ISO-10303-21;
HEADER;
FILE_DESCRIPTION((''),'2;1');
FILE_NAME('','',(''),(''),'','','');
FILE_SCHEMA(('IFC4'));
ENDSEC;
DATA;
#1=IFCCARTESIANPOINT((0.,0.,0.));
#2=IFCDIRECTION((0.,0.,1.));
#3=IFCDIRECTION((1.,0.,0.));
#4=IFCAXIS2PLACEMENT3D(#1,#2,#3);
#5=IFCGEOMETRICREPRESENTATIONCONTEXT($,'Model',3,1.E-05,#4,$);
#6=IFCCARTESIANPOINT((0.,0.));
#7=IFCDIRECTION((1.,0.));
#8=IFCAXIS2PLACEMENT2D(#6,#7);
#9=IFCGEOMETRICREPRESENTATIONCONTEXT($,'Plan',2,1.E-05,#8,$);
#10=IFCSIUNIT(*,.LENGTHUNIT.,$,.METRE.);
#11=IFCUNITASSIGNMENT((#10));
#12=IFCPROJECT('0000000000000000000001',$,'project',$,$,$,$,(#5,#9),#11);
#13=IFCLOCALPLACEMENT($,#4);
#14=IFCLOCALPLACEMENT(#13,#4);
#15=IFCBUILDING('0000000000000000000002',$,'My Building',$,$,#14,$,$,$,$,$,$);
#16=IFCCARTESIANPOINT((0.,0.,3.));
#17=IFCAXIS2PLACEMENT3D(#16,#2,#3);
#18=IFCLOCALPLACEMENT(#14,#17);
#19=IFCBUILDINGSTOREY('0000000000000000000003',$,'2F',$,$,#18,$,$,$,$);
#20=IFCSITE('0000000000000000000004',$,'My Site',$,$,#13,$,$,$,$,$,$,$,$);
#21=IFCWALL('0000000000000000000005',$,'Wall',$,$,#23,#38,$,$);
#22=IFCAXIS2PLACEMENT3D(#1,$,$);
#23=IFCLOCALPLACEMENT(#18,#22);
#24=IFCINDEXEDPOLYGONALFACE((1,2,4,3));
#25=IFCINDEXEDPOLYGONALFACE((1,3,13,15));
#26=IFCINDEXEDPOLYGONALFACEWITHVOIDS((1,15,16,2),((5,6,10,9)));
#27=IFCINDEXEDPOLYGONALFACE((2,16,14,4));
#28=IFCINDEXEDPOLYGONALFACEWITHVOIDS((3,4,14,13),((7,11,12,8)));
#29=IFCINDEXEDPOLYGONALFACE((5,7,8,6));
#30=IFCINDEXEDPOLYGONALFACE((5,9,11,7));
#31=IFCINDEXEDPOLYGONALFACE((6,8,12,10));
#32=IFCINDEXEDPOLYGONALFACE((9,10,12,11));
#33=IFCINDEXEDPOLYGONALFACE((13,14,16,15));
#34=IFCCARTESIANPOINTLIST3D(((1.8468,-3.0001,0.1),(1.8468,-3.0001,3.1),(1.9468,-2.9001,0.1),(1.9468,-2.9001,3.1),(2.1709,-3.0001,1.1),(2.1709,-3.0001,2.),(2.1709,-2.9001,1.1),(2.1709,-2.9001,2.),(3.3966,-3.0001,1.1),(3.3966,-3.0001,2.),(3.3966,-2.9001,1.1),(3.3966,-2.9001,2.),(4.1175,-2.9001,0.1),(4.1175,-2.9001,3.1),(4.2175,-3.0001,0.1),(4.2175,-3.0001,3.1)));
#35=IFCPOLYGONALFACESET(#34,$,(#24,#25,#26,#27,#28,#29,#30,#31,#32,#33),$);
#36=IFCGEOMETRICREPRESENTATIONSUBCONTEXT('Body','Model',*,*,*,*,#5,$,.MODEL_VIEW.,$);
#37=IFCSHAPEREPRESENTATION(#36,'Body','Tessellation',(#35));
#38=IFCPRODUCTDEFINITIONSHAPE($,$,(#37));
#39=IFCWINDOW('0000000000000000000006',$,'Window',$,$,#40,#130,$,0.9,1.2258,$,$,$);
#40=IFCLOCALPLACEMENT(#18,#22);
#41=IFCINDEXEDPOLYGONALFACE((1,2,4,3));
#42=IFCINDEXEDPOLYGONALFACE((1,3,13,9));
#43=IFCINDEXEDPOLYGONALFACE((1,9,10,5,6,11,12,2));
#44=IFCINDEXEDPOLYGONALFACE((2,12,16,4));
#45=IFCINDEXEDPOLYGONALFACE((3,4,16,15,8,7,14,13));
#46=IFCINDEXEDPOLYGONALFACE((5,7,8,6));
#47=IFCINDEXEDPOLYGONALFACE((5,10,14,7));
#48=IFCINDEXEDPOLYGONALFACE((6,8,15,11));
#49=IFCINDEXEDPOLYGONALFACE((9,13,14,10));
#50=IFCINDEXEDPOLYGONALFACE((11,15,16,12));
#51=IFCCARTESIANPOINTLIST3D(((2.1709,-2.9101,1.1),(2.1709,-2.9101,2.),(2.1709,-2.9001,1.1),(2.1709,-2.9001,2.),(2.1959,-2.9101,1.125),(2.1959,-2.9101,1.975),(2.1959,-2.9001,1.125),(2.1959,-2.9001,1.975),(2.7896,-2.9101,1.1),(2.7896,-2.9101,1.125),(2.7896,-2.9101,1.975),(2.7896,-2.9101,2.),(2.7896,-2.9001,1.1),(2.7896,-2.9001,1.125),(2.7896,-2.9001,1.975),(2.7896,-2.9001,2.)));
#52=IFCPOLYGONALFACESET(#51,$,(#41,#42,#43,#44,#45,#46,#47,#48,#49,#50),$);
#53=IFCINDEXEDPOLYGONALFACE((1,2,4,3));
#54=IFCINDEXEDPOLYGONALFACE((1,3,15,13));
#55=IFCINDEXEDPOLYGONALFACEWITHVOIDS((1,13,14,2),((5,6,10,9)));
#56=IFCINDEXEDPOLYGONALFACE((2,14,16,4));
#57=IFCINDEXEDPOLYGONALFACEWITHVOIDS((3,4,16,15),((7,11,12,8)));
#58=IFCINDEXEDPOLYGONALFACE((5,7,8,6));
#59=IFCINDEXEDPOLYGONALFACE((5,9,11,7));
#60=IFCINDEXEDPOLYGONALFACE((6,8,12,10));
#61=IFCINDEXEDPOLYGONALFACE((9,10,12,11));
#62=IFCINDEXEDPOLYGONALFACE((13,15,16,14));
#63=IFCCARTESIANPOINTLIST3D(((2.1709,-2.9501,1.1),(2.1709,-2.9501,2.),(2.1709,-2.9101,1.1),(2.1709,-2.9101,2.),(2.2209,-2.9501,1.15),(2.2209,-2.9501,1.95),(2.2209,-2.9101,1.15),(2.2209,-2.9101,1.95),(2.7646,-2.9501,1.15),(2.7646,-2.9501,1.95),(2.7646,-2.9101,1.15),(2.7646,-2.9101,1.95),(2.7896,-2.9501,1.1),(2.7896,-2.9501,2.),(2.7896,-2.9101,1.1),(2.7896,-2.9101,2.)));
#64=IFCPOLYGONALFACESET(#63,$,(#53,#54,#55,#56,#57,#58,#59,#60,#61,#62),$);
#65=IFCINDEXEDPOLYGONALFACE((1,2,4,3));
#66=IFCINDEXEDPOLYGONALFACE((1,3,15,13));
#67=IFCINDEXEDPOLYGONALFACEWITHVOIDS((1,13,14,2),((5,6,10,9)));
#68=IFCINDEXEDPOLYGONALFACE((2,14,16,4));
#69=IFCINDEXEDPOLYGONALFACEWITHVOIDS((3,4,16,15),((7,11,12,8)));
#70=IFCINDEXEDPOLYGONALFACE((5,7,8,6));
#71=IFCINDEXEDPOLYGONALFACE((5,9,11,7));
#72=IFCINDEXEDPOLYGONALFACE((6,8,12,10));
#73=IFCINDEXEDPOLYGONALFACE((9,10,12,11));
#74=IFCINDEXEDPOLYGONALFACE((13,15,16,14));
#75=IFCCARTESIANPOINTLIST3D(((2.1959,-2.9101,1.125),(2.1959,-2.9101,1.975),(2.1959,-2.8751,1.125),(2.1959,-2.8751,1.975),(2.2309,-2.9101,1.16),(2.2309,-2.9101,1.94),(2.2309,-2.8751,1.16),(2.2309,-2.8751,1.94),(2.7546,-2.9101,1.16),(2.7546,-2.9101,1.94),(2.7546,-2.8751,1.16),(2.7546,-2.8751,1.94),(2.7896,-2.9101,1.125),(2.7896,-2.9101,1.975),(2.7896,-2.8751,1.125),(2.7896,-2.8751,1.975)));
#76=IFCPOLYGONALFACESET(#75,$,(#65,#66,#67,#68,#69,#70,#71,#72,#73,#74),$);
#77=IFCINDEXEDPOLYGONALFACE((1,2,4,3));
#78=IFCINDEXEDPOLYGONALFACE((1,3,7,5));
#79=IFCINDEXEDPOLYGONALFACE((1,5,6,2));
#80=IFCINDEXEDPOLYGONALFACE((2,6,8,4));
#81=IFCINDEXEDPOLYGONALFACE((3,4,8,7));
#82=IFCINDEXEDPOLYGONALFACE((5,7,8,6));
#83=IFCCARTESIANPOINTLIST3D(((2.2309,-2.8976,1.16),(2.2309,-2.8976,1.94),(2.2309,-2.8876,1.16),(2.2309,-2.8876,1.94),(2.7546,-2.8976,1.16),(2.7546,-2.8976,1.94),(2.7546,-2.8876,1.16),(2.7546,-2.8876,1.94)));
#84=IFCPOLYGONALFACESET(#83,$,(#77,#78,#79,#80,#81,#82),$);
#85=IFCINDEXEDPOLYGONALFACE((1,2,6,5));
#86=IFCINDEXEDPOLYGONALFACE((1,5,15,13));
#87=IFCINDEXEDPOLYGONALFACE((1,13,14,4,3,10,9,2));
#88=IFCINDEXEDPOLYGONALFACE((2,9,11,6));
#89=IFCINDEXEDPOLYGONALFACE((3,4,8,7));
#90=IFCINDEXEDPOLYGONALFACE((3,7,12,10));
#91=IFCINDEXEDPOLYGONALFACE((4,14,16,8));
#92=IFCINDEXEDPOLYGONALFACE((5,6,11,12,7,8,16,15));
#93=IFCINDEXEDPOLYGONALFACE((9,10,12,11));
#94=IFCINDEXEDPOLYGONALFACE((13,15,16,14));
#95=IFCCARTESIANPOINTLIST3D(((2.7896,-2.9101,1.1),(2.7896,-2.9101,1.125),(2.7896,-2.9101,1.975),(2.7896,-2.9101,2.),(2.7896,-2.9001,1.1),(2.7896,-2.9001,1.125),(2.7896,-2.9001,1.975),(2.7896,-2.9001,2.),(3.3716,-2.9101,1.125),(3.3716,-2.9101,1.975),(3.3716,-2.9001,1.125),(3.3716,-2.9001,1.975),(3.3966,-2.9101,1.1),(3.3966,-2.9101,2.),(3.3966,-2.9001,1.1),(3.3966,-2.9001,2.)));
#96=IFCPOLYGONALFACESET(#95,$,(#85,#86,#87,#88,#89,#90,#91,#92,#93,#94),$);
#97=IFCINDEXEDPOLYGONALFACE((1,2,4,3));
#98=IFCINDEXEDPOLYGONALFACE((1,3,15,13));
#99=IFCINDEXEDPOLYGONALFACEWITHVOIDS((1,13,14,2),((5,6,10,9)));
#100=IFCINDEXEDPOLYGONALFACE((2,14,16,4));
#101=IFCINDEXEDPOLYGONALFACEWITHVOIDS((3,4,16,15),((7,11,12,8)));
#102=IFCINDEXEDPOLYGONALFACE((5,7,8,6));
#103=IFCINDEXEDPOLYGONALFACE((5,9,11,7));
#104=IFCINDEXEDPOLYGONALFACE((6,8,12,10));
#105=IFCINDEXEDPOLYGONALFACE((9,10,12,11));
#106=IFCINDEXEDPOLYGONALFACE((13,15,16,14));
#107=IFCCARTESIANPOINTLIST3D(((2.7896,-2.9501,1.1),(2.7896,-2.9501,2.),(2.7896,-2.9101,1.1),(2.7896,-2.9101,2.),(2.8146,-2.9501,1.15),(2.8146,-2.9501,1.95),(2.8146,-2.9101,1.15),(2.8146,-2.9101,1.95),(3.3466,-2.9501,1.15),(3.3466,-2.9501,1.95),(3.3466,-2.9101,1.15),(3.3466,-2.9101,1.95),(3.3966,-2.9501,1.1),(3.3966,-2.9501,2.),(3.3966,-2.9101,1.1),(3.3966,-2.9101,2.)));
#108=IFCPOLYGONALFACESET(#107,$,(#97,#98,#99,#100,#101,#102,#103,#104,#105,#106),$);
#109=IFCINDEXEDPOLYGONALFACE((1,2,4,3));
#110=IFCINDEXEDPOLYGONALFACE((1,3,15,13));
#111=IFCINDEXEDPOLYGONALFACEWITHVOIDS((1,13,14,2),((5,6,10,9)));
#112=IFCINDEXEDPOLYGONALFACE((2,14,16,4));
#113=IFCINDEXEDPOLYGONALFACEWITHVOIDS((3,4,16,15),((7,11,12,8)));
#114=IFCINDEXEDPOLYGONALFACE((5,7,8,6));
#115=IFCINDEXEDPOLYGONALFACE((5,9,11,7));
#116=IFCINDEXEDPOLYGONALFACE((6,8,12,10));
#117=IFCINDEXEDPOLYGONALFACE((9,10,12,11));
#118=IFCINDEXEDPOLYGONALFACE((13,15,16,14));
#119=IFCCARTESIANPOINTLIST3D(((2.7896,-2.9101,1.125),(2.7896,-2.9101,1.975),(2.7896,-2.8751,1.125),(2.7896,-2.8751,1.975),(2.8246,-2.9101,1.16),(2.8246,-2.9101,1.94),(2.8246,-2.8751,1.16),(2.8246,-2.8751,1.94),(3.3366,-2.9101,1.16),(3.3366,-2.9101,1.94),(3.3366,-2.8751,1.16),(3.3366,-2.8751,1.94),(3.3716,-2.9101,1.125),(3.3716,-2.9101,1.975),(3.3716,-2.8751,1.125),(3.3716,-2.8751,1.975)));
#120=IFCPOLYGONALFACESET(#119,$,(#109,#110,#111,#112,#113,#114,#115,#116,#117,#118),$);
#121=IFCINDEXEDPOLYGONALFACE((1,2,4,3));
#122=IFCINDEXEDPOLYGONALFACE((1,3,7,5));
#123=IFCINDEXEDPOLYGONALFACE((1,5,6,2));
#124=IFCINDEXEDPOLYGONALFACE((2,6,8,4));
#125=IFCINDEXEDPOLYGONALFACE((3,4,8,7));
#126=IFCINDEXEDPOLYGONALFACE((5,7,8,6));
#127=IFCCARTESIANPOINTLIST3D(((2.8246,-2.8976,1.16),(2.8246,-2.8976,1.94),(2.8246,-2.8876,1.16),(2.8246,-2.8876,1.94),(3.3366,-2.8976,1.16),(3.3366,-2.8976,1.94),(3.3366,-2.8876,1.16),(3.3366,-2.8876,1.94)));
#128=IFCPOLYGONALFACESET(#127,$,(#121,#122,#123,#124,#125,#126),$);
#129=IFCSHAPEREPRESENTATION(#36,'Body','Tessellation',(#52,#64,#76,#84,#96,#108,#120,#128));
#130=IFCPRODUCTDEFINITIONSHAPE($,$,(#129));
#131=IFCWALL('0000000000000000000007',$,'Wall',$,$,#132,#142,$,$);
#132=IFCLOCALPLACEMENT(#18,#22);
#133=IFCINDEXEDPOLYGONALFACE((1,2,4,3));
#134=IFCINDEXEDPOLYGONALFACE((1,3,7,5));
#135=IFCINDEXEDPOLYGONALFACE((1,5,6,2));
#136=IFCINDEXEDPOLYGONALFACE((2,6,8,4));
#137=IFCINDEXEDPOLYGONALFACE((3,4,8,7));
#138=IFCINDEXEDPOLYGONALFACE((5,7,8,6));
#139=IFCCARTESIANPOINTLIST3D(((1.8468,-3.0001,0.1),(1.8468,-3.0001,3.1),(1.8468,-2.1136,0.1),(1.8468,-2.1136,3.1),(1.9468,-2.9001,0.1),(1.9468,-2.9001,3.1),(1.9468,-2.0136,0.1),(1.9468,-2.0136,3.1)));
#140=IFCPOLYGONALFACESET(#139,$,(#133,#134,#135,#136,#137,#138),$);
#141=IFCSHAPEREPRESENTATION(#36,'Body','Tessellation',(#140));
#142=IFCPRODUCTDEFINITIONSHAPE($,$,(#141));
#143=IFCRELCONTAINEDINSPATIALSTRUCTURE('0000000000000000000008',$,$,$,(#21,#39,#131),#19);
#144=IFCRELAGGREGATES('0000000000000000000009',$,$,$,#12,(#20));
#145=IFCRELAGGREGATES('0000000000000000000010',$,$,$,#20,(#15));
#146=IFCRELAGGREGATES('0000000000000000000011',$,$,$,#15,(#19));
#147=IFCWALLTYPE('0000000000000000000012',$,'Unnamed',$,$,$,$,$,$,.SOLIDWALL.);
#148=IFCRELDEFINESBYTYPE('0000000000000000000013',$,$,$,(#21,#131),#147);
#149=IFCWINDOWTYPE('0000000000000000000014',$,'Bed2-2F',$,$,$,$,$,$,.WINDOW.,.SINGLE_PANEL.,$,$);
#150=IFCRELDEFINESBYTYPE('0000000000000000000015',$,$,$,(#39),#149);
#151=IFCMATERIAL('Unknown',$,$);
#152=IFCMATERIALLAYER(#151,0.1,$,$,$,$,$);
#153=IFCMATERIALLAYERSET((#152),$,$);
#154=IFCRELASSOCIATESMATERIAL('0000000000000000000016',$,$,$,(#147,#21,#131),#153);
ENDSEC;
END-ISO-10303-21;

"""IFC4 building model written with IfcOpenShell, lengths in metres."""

from ifc_helpers import new_model, entity, si_unit, frame, origin_with_axes, origin_2d_with_axis, place, context, subcontext, project, spatial, line, indexed_curve, outline, extrude, shape, source, transform, mapped, material, layer, layer_set, layer_usage, type_object, type_shapes, element, fill, save


model = new_model("IFC4")

# Units and contexts
model_context = context("Model", 3, precision=1e-05, world=origin_with_axes())
plan_context = context("Plan", 2, precision=1e-05, world=origin_2d_with_axis())
body_context_1 = subcontext(model_context, "Body", "Model", "MODEL_VIEW")
body_context_2 = subcontext(plan_context, "Body", "Plan", "PLAN_VIEW")
ifc_project = project(units=[si_unit("LENGTHUNIT", "METRE")], contexts=[model_context, plan_context])

# Site, building, storey
site_placement = place(None, origin_with_axes())
site = spatial("IfcSite", under=ifc_project, at=site_placement, Name="My Site")
building_placement = place(site_placement, origin_with_axes())
building = spatial("IfcBuilding", under=site, at=building_placement, Name="My Building")
storey_placement = place(building_placement, frame((0.0, 0.0, 3.0), z_axis=(0.0, 0.0, 1.0), x_axis=(1.0, 0.0, 0.0)))
storey = spatial("IfcBuildingStorey", under=building, at=storey_placement, Name="2F")

# Shared definitions
ifc_material = material(Name="Unknown")

# Shared definitions
ifc_layer_1 = layer(ifc_material, 0.1)
ifc_layer_set_1 = layer_set([ifc_layer_1])
wall_type = type_object("IfcWallType", Name="Unnamed", PredefinedType="SOLIDWALL", material=ifc_layer_set_1)

# Wall, opening, window
ifc_layer_usage_1 = layer_usage(ifc_layer_set_1, "AXIS2", "POSITIVE", 0.0)
wall_1_placement = place(storey_placement, frame((4.1175, -2.9001, 0.1), z_axis=(0.0, 0.0, 1.0), x_axis=(-1.0, 0.0, 0.0)))
wall_1 = element("IfcWall", 1, at=wall_1_placement, inside=storey, type_object=wall_type, material=ifc_layer_usage_1, Name="Wall", context=body_context_1, shape_type="SweptSolid", body=[
    extrude(outline(indexed_curve([(0.0, 0.0), (-0.1, 0.1), (2.2706, 0.1), (2.1706, 0.0)], segments=[line(1, 2, 3, 4, 1)])), origin_with_axes(), (0.0, 0.0, 1.0), 3.0),
])
shared_shape_1 = source(origin_with_axes(), body_context_1, "Body", "SweptSolid", [
    extrude(outline(indexed_curve([(0.0, 0.0), (1.2258, 0.0), (1.2258, 0.9), (0.0, 0.9)], segments=[line(1, 2, 3, 4, 1)])), frame((0.0, -0.6, 0.0), z_axis=(0.0, -1.0, 0.0), x_axis=(1.0, 0.0, 0.0)), (0.0, 0.0, -1.0), 1.2),
])
opening_1_placement = place(wall_1_placement, frame((1.9466, 0.1, 1.0), z_axis=(0.0, 0.0, 1.0), x_axis=(-1.0, 0.0, 0.0)))
opening_1 = element("IfcOpeningElement", 2, at=opening_1_placement, cuts=wall_1, PredefinedType="OPENING", context=body_context_1, shape_type="MappedRepresentation", body=[
    mapped(shared_shape_1, transform((0.0, 0.0, 0.0), x_axis=(1.0, 0.0, 0.0), y_axis=(0.0, 1.0, 0.0), z_axis=(0.0, 0.0, 1.0), scale=1.0)),
])
window_type_1 = type_object("IfcWindowType", Name="Bed2-2F", PartitioningType="SINGLE_PANEL", PredefinedType="WINDOW")
shared_shape_2 = source(origin_with_axes(), body_context_1, "Body", "SweptSolid", [
    extrude(outline(indexed_curve([(0.6187, 0.0), (0.0, 0.0), (0.0, 0.9), (0.6187, 0.9), (0.6187, 0.875), (0.025, 0.875), (0.025, 0.025), (0.6187, 0.025)], segments=[line(1, 2, 3, 4, 5, 6, 7, 8, 1)])), frame((0.0, 0.09, 0.0), z_axis=(0.0, -1.0, 0.0), x_axis=(1.0, 0.0, 0.0)), (0.0, 0.0, -1.0), 0.01),
    extrude(outline(indexed_curve([(0.0, 0.0), (0.6187, 0.0), (0.6187, 0.9), (0.0, 0.9)], segments=[line(1, 2, 3, 4, 1)]), holes=[indexed_curve([(0.05, 0.05), (0.5937, 0.05), (0.5937, 0.85), (0.05, 0.85)], segments=[line(1, 2, 3, 4, 1)])]), frame((0.0, 0.05, 0.0), z_axis=(0.0, -1.0, 0.0), x_axis=(1.0, 0.0, 0.0)), (0.0, 0.0, -1.0), 0.04),
    extrude(outline(indexed_curve([(0.0, 0.0), (0.5937, 0.0), (0.5937, 0.85), (0.0, 0.85)], segments=[line(1, 2, 3, 4, 1)]), holes=[indexed_curve([(0.035, 0.035), (0.5587, 0.035), (0.5587, 0.815), (0.035, 0.815)], segments=[line(1, 2, 3, 4, 1)])]), frame((0.025, 0.09, 0.025), z_axis=(0.0, -1.0, 0.0), x_axis=(1.0, 0.0, 0.0)), (0.0, 0.0, -1.0), 0.035),
    extrude(outline(indexed_curve([(0.035, 0.035), (0.5587, 0.035), (0.5587, 0.815), (0.035, 0.815)], segments=[line(1, 2, 3, 4, 1)])), frame((0.025, 0.1025, 0.025), z_axis=(0.0, -1.0, 0.0), x_axis=(1.0, 0.0, 0.0)), (0.0, 0.0, -1.0), 0.01),
    extrude(outline(indexed_curve([(0.0, 0.9), (0.6071, 0.9), (0.6071, 0.0), (0.0, 0.0), (0.0, 0.025), (0.5821, 0.025), (0.5821, 0.875), (0.0, 0.875)], segments=[line(1, 2, 3, 4, 5, 6, 7, 8, 1)])), frame((0.6187, 0.09, 0.0), z_axis=(0.0, -1.0, 0.0), x_axis=(1.0, 0.0, 0.0)), (0.0, 0.0, -1.0), 0.01),
    extrude(outline(indexed_curve([(0.0, 0.0), (0.6071, 0.0), (0.6071, 0.9), (0.0, 0.9)], segments=[line(1, 2, 3, 4, 1)]), holes=[indexed_curve([(0.025, 0.05), (0.5571, 0.05), (0.5571, 0.85), (0.025, 0.85)], segments=[line(1, 2, 3, 4, 1)])]), frame((0.6187, 0.05, 0.0), z_axis=(0.0, -1.0, 0.0), x_axis=(1.0, 0.0, 0.0)), (0.0, 0.0, -1.0), 0.04),
    extrude(outline(indexed_curve([(0.0, 0.0), (0.5821, 0.0), (0.5821, 0.85), (0.0, 0.85)], segments=[line(1, 2, 3, 4, 1)]), holes=[indexed_curve([(0.035, 0.035), (0.5471, 0.035), (0.5471, 0.815), (0.035, 0.815)], segments=[line(1, 2, 3, 4, 1)])]), frame((0.6187, 0.09, 0.025), z_axis=(0.0, -1.0, 0.0), x_axis=(1.0, 0.0, 0.0)), (0.0, 0.0, -1.0), 0.035),
    extrude(outline(indexed_curve([(0.035, 0.035), (0.5471, 0.035), (0.5471, 0.815), (0.035, 0.815)], segments=[line(1, 2, 3, 4, 1)])), frame((0.6187, 0.1025, 0.025), z_axis=(0.0, -1.0, 0.0), x_axis=(1.0, 0.0, 0.0)), (0.0, 0.0, -1.0), 0.01),
])
shared_shape_3 = source(origin_with_axes(), body_context_2, "Body", "Curve2D", [
    entity("IfcIndexedPolyCurve", entity("IfcCartesianPointList2D", [[0.05, 0.05], [0.5937, 0.05]])),
    entity("IfcIndexedPolyCurve", entity("IfcCartesianPointList2D", [[0.0, 0.1], [0.025, 0.1], [0.025, 0.09], [0.05, 0.09], [0.05, 0.05], [0.0, 0.05]]), [entity("IfcLineIndex", [1, 2, 3, 4, 5, 6, 1])]),
    entity("IfcIndexedPolyCurve", entity("IfcCartesianPointList2D", [[0.6187, 0.1], [0.6187, 0.1], [0.6187, 0.09], [0.5937, 0.09], [0.5937, 0.05], [0.6187, 0.05]])),
    entity("IfcIndexedPolyCurve", entity("IfcCartesianPointList2D", [[0.025, 0.09], [0.06, 0.09], [0.06, 0.125], [0.025, 0.125]]), [entity("IfcLineIndex", [1, 2, 3, 4, 1])]),
    entity("IfcIndexedPolyCurve", entity("IfcCartesianPointList2D", [[0.6187, 0.09], [0.5837, 0.09], [0.5837, 0.125], [0.6187, 0.125]]), [entity("IfcLineIndex", [1, 2, 3, 4, 1])]),
    entity("IfcIndexedPolyCurve", entity("IfcCartesianPointList2D", [[0.06, 0.09], [0.5837, 0.09]])),
    entity("IfcIndexedPolyCurve", entity("IfcCartesianPointList2D", [[0.06, 0.125], [0.5837, 0.125]])),
    entity("IfcIndexedPolyCurve", entity("IfcCartesianPointList2D", [[0.06, 0.1075], [0.5837, 0.1075]])),
    entity("IfcIndexedPolyCurve", entity("IfcCartesianPointList2D", [[0.6437, 0.05], [1.1758, 0.05]])),
    entity("IfcIndexedPolyCurve", entity("IfcCartesianPointList2D", [[0.6187, 0.1], [0.6187, 0.1], [0.6187, 0.09], [0.6437, 0.09], [0.6437, 0.05], [0.6187, 0.05]])),
    entity("IfcIndexedPolyCurve", entity("IfcCartesianPointList2D", [[1.2258, 0.1], [1.2008, 0.1], [1.2008, 0.09], [1.1758, 0.09], [1.1758, 0.05], [1.2258, 0.05]]), [entity("IfcLineIndex", [1, 2, 3, 4, 5, 6, 1])]),
    entity("IfcIndexedPolyCurve", entity("IfcCartesianPointList2D", [[0.6187, 0.09], [0.6537, 0.09], [0.6537, 0.125], [0.6187, 0.125]]), [entity("IfcLineIndex", [1, 2, 3, 4, 1])]),
    entity("IfcIndexedPolyCurve", entity("IfcCartesianPointList2D", [[1.2008, 0.09], [1.1658, 0.09], [1.1658, 0.125], [1.2008, 0.125]]), [entity("IfcLineIndex", [1, 2, 3, 4, 1])]),
    entity("IfcIndexedPolyCurve", entity("IfcCartesianPointList2D", [[0.6537, 0.09], [1.1658, 0.09]])),
    entity("IfcIndexedPolyCurve", entity("IfcCartesianPointList2D", [[0.6537, 0.125], [1.1658, 0.125]])),
    entity("IfcIndexedPolyCurve", entity("IfcCartesianPointList2D", [[0.6537, 0.1075], [1.1658, 0.1075]])),
])
type_shapes(window_type_1, [shared_shape_2, shared_shape_3])
window_1_placement = place(opening_1_placement, frame((0.0, 0.0, 0.0), z_axis=(0.0, 0.0, 1.0), x_axis=(1.0, 0.0, 0.0)))
window_1 = element("IfcWindow", 3, at=window_1_placement, inside=storey, type_object=window_type_1, Name="Window", OverallHeight=0.9, OverallWidth=1.2258, shapes=[
    shape(body_context_1, "Body", "MappedRepresentation", [mapped(shared_shape_2, transform((0.0, 0.0, 0.0), x_axis=(1.0, 0.0, 0.0), y_axis=(0.0, 1.0, 0.0), z_axis=(0.0, 0.0, 1.0), scale=1.0))]),
    shape(body_context_2, "Body", "MappedRepresentation", [mapped(shared_shape_3, transform((0.0, 0.0, 0.0), x_axis=(1.0, 0.0, 0.0), y_axis=(0.0, 1.0, 0.0), z_axis=(0.0, 0.0, 1.0), scale=1.0))]),
])
fill(opening_1, window_1)

# Wall
ifc_layer_usage_2 = layer_usage(ifc_layer_set_1, "AXIS2", "POSITIVE", 0.0)
wall_2_placement = place(storey_placement, frame((1.9468, -2.9001, 0.1), z_axis=(0.0, 0.0, 1.0), x_axis=(0.000001, 1.0, 0.0)))
element("IfcWall", 4, at=wall_2_placement, inside=storey, type_object=wall_type, material=ifc_layer_usage_2, Name="Wall", context=body_context_1, shape_type="SweptSolid", body=[
    extrude(outline(indexed_curve([(0.0, 0.0), (-0.1, 0.1), (0.7865, 0.1), (0.8865, 0.0)], segments=[line(1, 2, 3, 4, 1)])), origin_with_axes(), (0.0, 0.0, 1.0), 3.0),
])

save(model, "model.ifc")
